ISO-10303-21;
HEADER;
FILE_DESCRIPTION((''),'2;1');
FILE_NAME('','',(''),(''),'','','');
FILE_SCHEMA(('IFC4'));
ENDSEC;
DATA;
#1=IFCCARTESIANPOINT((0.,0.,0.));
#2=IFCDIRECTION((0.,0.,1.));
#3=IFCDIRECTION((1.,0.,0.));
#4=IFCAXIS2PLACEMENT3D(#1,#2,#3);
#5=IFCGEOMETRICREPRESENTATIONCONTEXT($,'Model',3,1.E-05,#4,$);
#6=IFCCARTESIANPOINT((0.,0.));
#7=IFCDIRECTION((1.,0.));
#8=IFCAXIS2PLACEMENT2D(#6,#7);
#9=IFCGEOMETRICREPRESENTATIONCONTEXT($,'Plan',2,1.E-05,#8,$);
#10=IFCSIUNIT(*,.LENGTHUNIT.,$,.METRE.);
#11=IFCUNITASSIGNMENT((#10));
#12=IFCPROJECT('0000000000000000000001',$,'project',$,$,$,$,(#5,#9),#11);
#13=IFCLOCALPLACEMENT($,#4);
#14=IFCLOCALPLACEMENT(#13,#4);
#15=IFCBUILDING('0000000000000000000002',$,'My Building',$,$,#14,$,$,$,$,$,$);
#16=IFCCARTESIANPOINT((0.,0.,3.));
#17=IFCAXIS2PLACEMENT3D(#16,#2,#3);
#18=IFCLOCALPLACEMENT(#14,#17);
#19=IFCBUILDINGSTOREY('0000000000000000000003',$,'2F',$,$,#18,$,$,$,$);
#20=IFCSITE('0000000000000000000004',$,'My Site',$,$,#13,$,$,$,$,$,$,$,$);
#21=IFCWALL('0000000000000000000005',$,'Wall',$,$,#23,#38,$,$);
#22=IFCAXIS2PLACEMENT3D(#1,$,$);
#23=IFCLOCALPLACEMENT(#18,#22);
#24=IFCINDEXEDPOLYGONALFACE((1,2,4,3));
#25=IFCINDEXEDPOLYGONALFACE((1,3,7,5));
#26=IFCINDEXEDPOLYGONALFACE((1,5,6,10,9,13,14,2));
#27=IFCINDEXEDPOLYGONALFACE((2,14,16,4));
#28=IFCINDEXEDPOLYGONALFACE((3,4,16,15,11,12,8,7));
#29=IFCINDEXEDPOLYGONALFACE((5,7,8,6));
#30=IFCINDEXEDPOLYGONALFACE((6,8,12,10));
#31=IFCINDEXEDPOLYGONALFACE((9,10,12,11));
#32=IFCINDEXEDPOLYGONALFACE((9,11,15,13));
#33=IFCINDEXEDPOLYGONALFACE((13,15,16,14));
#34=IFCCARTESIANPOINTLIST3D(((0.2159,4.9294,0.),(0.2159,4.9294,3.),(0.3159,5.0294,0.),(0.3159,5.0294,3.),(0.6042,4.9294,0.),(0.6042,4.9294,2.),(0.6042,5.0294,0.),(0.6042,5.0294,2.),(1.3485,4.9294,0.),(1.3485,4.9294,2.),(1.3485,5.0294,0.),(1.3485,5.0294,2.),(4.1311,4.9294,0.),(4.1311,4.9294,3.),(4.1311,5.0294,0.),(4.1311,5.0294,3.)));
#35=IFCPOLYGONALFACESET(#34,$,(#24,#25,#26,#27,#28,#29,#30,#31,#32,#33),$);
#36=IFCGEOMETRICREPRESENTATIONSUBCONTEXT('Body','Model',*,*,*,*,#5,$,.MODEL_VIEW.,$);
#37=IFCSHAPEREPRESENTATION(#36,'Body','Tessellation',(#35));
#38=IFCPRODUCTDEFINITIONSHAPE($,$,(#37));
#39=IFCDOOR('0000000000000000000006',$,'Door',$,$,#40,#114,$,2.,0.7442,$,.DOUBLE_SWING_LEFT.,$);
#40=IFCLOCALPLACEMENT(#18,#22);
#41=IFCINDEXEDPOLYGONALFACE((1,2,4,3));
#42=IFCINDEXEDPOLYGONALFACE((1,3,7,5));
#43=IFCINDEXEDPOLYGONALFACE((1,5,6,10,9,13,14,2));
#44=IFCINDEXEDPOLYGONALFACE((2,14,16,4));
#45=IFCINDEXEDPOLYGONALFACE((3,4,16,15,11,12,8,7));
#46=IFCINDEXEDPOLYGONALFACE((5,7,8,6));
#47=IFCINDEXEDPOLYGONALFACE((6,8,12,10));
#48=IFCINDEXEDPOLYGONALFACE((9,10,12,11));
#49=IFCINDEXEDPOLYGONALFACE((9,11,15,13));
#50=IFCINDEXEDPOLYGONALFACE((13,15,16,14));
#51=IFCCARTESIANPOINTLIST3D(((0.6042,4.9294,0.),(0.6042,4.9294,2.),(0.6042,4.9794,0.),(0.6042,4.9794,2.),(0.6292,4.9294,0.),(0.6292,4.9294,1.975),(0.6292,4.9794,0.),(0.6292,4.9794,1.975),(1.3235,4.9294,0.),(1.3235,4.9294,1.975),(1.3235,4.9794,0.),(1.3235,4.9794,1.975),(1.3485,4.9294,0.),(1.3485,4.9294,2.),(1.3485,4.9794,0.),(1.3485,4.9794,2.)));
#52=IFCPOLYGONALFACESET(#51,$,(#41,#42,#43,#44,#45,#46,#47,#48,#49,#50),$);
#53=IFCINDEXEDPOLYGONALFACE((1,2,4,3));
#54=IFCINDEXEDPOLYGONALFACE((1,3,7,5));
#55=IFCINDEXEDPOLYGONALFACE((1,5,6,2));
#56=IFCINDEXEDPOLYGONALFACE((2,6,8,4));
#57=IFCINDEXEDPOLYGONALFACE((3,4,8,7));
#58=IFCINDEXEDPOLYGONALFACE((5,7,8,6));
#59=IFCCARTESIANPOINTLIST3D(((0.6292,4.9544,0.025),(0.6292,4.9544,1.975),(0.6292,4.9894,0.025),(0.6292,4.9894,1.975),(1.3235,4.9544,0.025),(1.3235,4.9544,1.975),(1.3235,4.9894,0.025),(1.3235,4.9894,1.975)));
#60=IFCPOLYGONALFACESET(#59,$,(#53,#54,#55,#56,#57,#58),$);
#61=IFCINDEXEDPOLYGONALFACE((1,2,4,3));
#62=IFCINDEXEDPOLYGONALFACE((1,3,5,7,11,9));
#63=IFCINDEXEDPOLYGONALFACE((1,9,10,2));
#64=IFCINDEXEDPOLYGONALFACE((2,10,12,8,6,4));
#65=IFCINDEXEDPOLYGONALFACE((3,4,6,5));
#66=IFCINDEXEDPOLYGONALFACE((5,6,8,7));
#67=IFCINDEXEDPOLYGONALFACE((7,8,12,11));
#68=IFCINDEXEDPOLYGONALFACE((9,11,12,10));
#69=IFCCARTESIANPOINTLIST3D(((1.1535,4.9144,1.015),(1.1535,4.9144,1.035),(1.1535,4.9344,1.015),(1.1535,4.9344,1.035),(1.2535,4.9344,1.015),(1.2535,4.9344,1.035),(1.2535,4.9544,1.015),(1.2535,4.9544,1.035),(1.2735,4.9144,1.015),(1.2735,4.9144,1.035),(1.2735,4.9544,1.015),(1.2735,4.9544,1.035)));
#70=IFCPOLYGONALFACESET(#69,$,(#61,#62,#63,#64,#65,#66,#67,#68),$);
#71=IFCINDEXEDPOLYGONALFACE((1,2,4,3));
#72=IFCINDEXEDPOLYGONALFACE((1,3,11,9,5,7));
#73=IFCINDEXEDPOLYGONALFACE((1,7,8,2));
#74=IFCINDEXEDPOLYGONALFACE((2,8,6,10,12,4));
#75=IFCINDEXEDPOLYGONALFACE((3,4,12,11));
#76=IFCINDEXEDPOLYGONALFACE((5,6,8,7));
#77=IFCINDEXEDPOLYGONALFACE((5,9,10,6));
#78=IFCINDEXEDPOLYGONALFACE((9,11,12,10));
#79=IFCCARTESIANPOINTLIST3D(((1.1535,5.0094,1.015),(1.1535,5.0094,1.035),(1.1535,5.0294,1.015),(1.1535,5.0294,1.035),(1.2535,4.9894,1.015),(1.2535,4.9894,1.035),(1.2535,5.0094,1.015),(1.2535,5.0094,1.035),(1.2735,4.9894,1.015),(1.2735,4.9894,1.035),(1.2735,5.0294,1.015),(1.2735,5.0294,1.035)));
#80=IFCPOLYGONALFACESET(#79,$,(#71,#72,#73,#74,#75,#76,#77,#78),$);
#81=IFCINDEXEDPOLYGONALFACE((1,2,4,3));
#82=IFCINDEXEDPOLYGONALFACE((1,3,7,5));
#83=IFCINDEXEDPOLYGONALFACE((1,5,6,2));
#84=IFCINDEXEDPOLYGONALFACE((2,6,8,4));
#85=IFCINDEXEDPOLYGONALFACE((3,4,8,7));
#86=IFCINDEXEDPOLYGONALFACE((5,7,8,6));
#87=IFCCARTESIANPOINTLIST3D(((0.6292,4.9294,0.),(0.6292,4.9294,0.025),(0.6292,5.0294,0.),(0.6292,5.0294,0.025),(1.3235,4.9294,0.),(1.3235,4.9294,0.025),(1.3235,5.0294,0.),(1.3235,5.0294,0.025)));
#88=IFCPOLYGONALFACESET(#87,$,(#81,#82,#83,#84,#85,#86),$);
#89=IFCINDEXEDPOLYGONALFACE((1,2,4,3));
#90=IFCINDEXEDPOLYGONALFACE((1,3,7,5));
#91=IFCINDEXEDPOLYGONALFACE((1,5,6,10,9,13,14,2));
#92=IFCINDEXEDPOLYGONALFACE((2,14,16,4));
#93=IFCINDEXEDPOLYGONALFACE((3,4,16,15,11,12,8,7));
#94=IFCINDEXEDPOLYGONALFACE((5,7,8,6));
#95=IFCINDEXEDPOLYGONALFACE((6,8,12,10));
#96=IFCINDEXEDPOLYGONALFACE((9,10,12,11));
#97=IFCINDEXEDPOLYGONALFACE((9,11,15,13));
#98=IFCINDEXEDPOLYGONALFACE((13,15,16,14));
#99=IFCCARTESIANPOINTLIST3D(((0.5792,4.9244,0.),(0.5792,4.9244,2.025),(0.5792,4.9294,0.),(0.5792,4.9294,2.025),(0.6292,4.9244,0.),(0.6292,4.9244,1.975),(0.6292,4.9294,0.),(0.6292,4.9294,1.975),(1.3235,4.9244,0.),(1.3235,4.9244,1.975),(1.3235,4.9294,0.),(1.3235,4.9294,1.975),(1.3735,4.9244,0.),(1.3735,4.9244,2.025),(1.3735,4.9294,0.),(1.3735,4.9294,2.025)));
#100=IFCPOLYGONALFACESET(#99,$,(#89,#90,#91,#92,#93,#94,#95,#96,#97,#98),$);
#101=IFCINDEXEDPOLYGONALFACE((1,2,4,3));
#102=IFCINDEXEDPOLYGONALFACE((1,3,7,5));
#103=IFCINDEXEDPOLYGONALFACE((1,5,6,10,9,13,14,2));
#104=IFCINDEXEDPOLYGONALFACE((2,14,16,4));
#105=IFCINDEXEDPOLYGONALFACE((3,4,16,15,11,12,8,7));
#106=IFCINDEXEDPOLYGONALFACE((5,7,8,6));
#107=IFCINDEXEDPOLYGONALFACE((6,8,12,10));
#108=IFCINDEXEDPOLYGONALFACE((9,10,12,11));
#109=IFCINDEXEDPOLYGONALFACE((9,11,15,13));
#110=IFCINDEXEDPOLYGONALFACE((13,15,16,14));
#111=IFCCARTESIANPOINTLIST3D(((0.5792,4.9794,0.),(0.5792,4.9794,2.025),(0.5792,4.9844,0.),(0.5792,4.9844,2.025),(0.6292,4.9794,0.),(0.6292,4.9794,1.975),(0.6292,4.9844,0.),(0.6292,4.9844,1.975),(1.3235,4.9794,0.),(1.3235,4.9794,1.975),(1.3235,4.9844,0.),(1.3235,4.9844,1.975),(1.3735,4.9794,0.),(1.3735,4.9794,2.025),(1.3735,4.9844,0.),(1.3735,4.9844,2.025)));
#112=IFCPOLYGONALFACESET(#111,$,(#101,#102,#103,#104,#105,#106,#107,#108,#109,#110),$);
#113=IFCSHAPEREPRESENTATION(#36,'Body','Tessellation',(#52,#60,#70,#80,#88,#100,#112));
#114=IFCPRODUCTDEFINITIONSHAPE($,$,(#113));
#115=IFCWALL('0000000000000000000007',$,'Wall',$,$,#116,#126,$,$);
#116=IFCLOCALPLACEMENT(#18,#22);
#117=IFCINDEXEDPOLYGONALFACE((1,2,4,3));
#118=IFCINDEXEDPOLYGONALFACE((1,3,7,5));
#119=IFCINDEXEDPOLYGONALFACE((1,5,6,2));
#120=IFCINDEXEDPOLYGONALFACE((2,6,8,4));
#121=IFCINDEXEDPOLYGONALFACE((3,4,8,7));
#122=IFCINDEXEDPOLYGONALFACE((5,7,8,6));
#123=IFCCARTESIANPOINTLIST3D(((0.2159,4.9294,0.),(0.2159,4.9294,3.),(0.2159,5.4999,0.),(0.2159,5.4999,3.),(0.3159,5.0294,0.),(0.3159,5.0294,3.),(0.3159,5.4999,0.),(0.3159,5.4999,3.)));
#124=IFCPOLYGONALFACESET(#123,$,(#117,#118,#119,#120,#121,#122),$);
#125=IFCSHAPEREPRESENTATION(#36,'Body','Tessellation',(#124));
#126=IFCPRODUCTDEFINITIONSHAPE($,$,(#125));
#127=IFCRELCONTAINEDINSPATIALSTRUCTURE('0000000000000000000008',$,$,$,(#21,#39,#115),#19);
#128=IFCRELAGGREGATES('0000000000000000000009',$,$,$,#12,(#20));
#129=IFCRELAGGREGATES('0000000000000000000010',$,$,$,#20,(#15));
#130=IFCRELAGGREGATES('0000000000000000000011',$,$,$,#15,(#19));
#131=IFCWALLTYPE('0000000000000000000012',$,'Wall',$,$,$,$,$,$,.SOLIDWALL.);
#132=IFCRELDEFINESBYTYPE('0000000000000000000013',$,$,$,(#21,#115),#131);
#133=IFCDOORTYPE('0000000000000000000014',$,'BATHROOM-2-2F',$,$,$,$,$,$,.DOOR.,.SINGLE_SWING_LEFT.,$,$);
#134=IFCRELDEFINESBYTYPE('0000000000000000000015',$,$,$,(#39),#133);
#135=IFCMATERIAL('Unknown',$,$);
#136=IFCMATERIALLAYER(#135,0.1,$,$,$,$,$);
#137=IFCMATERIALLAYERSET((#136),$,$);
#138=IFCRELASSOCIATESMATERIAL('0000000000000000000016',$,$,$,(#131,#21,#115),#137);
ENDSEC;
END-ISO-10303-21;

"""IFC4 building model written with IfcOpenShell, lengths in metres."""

from ifc_helpers import new_model, entity, si_unit, frame, origin_with_axes, origin_2d_with_axis, place, context, subcontext, project, spatial, line, indexed_curve, outline, extrude, shape, source, transform, mapped, material, layer, layer_set, layer_usage, type_object, type_shapes, element, fill, save


model = new_model("IFC4")

# Units and contexts
model_context = context("Model", 3, precision=1e-05, world=origin_with_axes())
plan_context = context("Plan", 2, precision=1e-05, world=origin_2d_with_axis())
body_context_1 = subcontext(model_context, "Body", "Model", "MODEL_VIEW")
body_context_2 = subcontext(plan_context, "Body", "Plan", "PLAN_VIEW")
ifc_project = project(units=[si_unit("LENGTHUNIT", "METRE")], contexts=[model_context, plan_context])

# Site, building, storey
site_placement = place(None, origin_with_axes())
site = spatial("IfcSite", under=ifc_project, at=site_placement, Name="My Site")
building_placement = place(site_placement, origin_with_axes())
building = spatial("IfcBuilding", under=site, at=building_placement, Name="My Building")
storey_placement = place(building_placement, frame((0.0, 0.0, 3.0), z_axis=(0.0, 0.0, 1.0), x_axis=(1.0, 0.0, 0.0)))
storey = spatial("IfcBuildingStorey", under=building, at=storey_placement, Name="2F")

# Shared definitions
ifc_material = material(Name="Unknown")

# Shared definitions
ifc_layer_1 = layer(ifc_material, 0.1)
ifc_layer_set_1 = layer_set([ifc_layer_1])
wall_type = type_object("IfcWallType", Name="Wall", PredefinedType="SOLIDWALL", material=ifc_layer_set_1)

# Wall, opening, door
ifc_layer_usage_1 = layer_usage(ifc_layer_set_1, "AXIS2", "POSITIVE", 0.0)
wall_1_placement = place(storey_placement, frame((4.1311, 5.0294, 0.0), z_axis=(0.0, 0.0, 1.0), x_axis=(-1.0, 0.0, 0.0)))
wall_1 = element("IfcWall", 1, at=wall_1_placement, inside=storey, type_object=wall_type, material=ifc_layer_usage_1, Name="Wall", context=body_context_1, shape_type="SweptSolid", body=[
    extrude(outline(indexed_curve([(0.0, 0.0), (0.0, 0.1), (3.9153, 0.1), (3.8153, 0.0)], segments=[line(1, 2, 3, 4, 1)])), origin_with_axes(), (0.0, 0.0, 1.0), 3.0),
])
shared_shape_1 = source(origin_with_axes(), body_context_1, "Body", "SweptSolid", [
    extrude(outline(indexed_curve([(0.0, 0.0), (0.7442, 0.0), (0.7442, 2.0), (0.0, 2.0)], segments=[line(1, 2, 3, 4, 1)])), frame((0.0, -0.6, 0.0), z_axis=(0.0, -1.0, 0.0), x_axis=(1.0, 0.0, 0.0)), (0.0, 0.0, -1.0), 1.2),
])
opening_1_placement = place(wall_1_placement, frame((3.5269, 0.1, 0.0), z_axis=(0.0, 0.0, 1.0), x_axis=(-1.0, 0.0, 0.0)))
opening_1 = element("IfcOpeningElement", 2, at=opening_1_placement, cuts=wall_1, PredefinedType="OPENING", context=body_context_1, shape_type="MappedRepresentation", body=[
    mapped(shared_shape_1, transform((0.0, 0.0, 0.0), x_axis=(1.0, 0.0, 0.0), y_axis=(0.0, 1.0, 0.0), z_axis=(0.0, 0.0, 1.0), scale=1.0)),
])
door_type_1 = type_object("IfcDoorType", Name="BATHROOM-2-2F", OperationType="SINGLE_SWING_LEFT", PredefinedType="DOOR")
shared_shape_2 = source(origin_with_axes(), body_context_1, "Body", "SweptSolid", [
    extrude(outline(indexed_curve([(0.0, 0.0), (0.0, 2.0), (0.7442, 2.0), (0.7442, 0.0), (0.7192, 0.0), (0.7192, 1.975), (0.025, 1.975), (0.025, 0.0)], segments=[line(1, 2, 3, 4, 5, 6, 7, 8, 1)])), frame((0.0, 0.0, 0.0), z_axis=(0.0, -1.0, 0.0), x_axis=(1.0, 0.0, 0.0)), (0.0, 0.0, -1.0), 0.05),
    extrude(outline(indexed_curve([(0.0, 0.0), (0.6942, 0.0), (0.6942, 0.035), (0.0, 0.035)], segments=[line(1, 2, 3, 4, 1)])), frame((0.025, 0.025, 0.025), z_axis=(0.0, 0.0, 1.0), x_axis=(1.0, 0.0, 0.0)), (0.0, 0.0, 1.0), 1.95),
    extrude(outline(indexed_curve([(0.0, 0.0), (0.0, -0.04), (-0.12, -0.04), (-0.12, -0.02), (-0.02, -0.02), (-0.02, 0.0)], segments=[line(1, 2, 3, 4, 5, 6, 1)])), frame((0.6692, 0.025, 1.015), z_axis=(0.0, 0.0, 1.0), x_axis=(1.0, 0.0, 0.0)), (0.0, 0.0, 1.0), 0.02),
    extrude(outline(indexed_curve([(0.0, 0.0), (0.0, 0.04), (-0.12, 0.04), (-0.12, 0.02), (-0.02, 0.02), (-0.02, 0.0)], segments=[line(1, 2, 3, 4, 5, 6, 1)])), frame((0.6692, 0.06, 1.015), z_axis=(0.0, 0.0, 1.0), x_axis=(1.0, 0.0, 0.0)), (0.0, 0.0, 1.0), 0.02),
    extrude(outline(indexed_curve([(0.0, 0.0), (0.6942, 0.0), (0.6942, 0.1), (0.0, 0.1)], segments=[line(1, 2, 3, 4, 1)])), frame((0.025, 0.0, 0.0), z_axis=(0.0, 0.0, 1.0), x_axis=(1.0, 0.0, 0.0)), (0.0, 0.0, 1.0), 0.025),
    extrude(outline(indexed_curve([(0.0, 0.0), (0.0, 2.025), (0.7942, 2.025), (0.7942, 0.0), (0.7442, 0.0), (0.7442, 1.975), (0.05, 1.975), (0.05, 0.0)], segments=[line(1, 2, 3, 4, 5, 6, 7, 8, 1)])), frame((-0.025, -0.005, 0.0), z_axis=(0.0, -1.0, 0.0), x_axis=(1.0, 0.0, 0.0)), (0.0, 0.0, -1.0), 0.005),
    extrude(outline(indexed_curve([(0.0, 0.0), (0.0, 2.025), (0.7942, 2.025), (0.7942, 0.0), (0.7442, 0.0), (0.7442, 1.975), (0.05, 1.975), (0.05, 0.0)], segments=[line(1, 2, 3, 4, 5, 6, 7, 8, 1)])), frame((-0.025, 0.05, 0.0), z_axis=(0.0, -1.0, 0.0), x_axis=(1.0, 0.0, 0.0)), (0.0, 0.0, -1.0), 0.005),
])
shared_shape_3 = source(origin_with_axes(), body_context_2, "Body", "Curve2D", [
    entity("IfcIndexedPolyCurve", entity("IfcCartesianPointList2D", [[0.0, 0.0], [0.025, 0.0], [0.025, 0.05], [0.0, 0.05]]), [entity("IfcLineIndex", [1, 2, 3, 4, 1])]),
    entity("IfcIndexedPolyCurve", entity("IfcCartesianPointList2D", [[0.7442, 0.0], [0.7192, 0.0], [0.7192, 0.05], [0.7442, 0.05]]), [entity("IfcLineIndex", [1, 2, 3, 4, 1])]),
    entity("IfcIndexedPolyCurve", entity("IfcCartesianPointList2D", [[0.025, 0.05], [0.025, -0.6442], [0.06, -0.6442]])),
    entity("IfcTrimmedCurve", entity("IfcEllipse", entity("IfcAxis2Placement2D", entity("IfcCartesianPoint", [0.06, 0.05]), entity("IfcDirection", [1.0, 0.0])), 0.6592, 0.6942), [entity("IfcCartesianPoint", [0.06, -0.6442])], [entity("IfcCartesianPoint", [0.06, 0.7442])], True, "CARTESIAN"),
    entity("IfcIndexedPolyCurve", entity("IfcCartesianPointList2D", [[0.025, 0.05], [0.06, 0.05], [0.06, 0.7442], [0.025, 0.7442]]), [entity("IfcLineIndex", [1, 2, 3, 4, 1])]),
])
type_shapes(door_type_1, [shared_shape_2, shared_shape_3])
door_1_placement = place(opening_1_placement, frame((0.0, 0.0, 0.0), z_axis=(0.0, 0.0, 1.0), x_axis=(1.0, 0.0, 0.0)))
door_1 = element("IfcDoor", 3, at=door_1_placement, inside=storey, type_object=door_type_1, Name="Door", OperationType="DOUBLE_SWING_LEFT", OverallHeight=2.0, OverallWidth=0.7442, shapes=[
    shape(body_context_1, "Body", "MappedRepresentation", [mapped(shared_shape_2, transform((0.0, 0.0, 0.0), x_axis=(1.0, 0.0, 0.0), y_axis=(0.0, 1.0, 0.0), z_axis=(0.0, 0.0, 1.0), scale=1.0))]),
    shape(body_context_2, "Body", "MappedRepresentation", [mapped(shared_shape_3, transform((0.0, 0.0, 0.0), x_axis=(1.0, 0.0, 0.0), y_axis=(0.0, 1.0, 0.0), z_axis=(0.0, 0.0, 1.0), scale=1.0))]),
])
fill(opening_1, door_1)

# Wall
ifc_layer_usage_2 = layer_usage(ifc_layer_set_1, "AXIS2", "POSITIVE", 0.0)
wall_2_placement = place(storey_placement, frame((0.3159, 5.0294, 0.0), z_axis=(0.0, 0.0, 1.0), x_axis=(0.0, 1.0, 0.0)))
element("IfcWall", 4, at=wall_2_placement, inside=storey, type_object=wall_type, material=ifc_layer_usage_2, Name="Wall", context=body_context_1, shape_type="SweptSolid", body=[
    extrude(outline(indexed_curve([(0.0, 0.0), (-0.1, 0.1), (0.4705, 0.1), (0.4705, 0.0)], segments=[line(1, 2, 3, 4, 1)])), origin_with_axes(), (0.0, 0.0, 1.0), 3.0),
])

save(model, "model.ifc")
